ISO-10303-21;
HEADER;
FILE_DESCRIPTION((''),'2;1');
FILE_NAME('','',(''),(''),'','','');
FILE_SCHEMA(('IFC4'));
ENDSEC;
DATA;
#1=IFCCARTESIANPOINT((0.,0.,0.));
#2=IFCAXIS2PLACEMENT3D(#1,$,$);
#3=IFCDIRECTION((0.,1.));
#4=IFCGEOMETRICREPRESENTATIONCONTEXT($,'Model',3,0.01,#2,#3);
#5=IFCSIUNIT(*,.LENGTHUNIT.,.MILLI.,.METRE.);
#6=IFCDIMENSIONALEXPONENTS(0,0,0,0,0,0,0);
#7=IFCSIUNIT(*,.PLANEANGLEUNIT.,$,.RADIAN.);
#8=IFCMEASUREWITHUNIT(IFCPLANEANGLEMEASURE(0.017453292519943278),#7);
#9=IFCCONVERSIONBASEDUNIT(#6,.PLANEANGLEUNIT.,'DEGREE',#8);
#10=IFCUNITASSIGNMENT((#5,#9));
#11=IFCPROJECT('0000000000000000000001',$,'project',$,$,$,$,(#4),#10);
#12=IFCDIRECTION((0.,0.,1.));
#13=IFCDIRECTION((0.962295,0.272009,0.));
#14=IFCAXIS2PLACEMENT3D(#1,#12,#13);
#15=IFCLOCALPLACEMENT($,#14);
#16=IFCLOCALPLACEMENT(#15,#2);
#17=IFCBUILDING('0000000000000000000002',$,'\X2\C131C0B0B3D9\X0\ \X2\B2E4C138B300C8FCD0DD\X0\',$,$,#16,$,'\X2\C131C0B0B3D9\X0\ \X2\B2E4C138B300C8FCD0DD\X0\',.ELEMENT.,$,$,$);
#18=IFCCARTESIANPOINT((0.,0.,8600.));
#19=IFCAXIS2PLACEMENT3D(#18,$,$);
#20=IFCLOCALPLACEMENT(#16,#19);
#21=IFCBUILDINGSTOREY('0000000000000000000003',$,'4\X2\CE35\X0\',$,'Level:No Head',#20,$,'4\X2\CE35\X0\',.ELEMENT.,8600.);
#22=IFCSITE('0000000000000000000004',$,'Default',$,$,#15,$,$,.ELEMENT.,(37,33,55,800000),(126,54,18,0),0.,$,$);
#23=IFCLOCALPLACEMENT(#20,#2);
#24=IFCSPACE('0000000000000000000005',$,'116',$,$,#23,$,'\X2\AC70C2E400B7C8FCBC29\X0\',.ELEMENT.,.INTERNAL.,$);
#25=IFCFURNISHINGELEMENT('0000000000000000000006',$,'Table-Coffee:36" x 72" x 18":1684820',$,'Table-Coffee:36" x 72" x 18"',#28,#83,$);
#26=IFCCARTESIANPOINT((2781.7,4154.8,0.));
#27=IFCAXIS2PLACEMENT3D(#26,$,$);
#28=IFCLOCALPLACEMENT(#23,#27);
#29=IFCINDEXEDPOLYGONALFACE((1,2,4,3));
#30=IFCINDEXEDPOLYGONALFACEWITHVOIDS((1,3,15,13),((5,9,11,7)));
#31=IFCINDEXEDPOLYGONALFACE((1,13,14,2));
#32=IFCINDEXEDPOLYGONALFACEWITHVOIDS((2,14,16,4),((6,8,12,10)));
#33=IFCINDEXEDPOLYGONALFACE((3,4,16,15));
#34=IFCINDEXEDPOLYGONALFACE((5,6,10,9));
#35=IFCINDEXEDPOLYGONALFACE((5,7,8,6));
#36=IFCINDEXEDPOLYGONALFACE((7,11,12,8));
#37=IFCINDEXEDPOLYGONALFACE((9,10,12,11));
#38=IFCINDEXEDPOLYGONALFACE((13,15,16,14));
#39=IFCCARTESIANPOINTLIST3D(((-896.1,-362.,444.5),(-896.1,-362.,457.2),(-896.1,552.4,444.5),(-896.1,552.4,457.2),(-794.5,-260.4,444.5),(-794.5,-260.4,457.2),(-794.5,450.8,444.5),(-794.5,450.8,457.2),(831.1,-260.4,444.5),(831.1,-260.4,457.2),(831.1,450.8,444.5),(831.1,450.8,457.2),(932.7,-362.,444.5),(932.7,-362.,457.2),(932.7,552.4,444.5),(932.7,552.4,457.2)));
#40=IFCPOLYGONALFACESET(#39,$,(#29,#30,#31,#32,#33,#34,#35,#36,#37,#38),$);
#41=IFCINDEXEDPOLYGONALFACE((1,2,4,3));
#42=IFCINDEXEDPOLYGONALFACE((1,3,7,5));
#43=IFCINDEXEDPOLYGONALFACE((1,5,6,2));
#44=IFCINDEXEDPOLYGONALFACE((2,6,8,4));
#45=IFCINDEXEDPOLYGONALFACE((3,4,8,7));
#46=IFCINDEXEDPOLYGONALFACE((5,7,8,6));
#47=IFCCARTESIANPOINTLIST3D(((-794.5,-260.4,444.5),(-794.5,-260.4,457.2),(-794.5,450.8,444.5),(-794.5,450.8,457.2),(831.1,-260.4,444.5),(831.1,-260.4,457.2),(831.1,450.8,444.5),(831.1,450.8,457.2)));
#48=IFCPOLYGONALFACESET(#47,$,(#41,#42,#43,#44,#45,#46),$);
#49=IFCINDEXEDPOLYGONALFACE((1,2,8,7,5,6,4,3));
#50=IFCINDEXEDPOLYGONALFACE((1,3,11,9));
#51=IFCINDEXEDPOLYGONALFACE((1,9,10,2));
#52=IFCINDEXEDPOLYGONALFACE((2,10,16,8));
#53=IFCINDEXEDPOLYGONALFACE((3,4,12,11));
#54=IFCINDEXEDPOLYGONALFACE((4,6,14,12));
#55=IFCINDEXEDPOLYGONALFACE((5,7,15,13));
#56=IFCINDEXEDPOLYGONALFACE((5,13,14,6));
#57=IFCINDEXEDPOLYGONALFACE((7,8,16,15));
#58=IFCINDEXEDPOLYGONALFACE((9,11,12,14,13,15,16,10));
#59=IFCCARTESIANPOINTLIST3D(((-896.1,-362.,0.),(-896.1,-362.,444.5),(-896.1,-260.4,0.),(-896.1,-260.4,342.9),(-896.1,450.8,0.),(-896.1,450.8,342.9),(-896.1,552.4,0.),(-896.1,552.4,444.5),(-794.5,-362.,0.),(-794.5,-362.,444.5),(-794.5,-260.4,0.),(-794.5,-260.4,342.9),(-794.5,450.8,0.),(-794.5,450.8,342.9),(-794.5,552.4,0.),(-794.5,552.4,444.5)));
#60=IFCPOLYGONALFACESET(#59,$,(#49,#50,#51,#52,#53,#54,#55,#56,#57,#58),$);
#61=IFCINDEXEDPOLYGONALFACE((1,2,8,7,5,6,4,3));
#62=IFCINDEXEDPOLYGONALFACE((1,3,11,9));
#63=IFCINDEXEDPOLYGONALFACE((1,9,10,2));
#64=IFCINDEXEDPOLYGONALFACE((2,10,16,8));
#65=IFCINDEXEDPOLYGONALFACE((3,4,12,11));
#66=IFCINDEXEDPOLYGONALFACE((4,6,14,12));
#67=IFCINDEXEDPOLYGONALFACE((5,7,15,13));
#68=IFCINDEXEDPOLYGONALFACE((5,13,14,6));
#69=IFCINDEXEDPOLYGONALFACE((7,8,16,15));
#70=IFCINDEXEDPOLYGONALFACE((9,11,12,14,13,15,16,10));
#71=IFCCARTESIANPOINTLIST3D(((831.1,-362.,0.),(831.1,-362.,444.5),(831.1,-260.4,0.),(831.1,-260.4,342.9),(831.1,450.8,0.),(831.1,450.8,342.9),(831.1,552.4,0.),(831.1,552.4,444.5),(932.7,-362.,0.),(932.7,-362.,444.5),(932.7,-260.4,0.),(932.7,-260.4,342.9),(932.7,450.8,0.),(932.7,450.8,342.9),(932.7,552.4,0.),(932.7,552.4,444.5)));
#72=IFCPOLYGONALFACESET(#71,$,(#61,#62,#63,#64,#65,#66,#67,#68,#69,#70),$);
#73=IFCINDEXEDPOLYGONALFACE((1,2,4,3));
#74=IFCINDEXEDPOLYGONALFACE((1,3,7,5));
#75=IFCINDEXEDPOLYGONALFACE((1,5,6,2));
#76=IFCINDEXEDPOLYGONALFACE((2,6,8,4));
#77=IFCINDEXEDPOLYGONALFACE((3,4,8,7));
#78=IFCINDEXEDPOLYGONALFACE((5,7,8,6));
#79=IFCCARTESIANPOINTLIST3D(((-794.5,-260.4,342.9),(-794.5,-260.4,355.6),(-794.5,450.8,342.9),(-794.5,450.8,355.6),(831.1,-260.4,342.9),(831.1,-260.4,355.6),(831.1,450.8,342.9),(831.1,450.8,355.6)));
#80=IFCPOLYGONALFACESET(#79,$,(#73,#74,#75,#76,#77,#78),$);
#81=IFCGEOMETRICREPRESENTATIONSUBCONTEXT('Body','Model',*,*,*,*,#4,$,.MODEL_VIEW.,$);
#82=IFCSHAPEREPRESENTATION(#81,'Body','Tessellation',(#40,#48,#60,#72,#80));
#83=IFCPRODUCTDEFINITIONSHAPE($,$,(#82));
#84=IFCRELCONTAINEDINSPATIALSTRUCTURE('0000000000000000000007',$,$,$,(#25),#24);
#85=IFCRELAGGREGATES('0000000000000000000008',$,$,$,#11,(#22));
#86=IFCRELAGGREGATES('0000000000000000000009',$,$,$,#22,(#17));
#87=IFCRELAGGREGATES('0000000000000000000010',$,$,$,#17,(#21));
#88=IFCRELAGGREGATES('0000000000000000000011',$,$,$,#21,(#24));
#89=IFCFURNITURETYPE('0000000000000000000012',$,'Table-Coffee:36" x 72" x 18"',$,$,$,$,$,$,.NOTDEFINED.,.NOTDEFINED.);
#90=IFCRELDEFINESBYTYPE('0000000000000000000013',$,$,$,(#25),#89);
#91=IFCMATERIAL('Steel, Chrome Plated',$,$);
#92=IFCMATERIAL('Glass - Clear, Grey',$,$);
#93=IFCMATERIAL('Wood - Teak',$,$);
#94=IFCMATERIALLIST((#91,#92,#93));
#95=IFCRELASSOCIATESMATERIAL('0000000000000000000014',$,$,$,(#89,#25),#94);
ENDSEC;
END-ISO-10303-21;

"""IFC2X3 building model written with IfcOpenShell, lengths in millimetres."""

from ifc_helpers import new_model, entity, si_unit, converted_unit, direction, frame, origin, origin_2d_with_axis, place, context, subcontext, project, spatial, polyline, rectangle, outline, extrude, source, transform, mapped, material, material_list, type_object, type_shapes, element, save


model = new_model("IFC2X3")

# Units and contexts
model_context = context("Model", 3, precision=0.01, world=origin(), true_north=direction((0.0, 1.0)))
body_context = subcontext(model_context, "Body", "Model", "MODEL_VIEW")
ifc_project = project(units=[si_unit("LENGTHUNIT", "METRE", prefix="MILLI"), converted_unit("PLANEANGLEUNIT", "DEGREE", entity("IfcPlaneAngleMeasure", 0.017453292519943278), si_unit("PLANEANGLEUNIT", "RADIAN"), dimensions=[0, 0, 0, 0, 0, 0, 0])], contexts=[model_context])

# Site, building, storey
site_placement = place(None, frame((0.0, 0.0, 0.0), z_axis=(0.0, 0.0, 1.0), x_axis=(0.962295, 0.272009, 0.0)))
site = spatial("IfcSite", under=ifc_project, at=site_placement, Name="Default", CompositionType="ELEMENT", RefLatitude=(37, 33, 55, 800000), RefLongitude=(126, 54, 18, 0), RefElevation=0.0)
building_placement = place(site_placement, origin())
building = spatial("IfcBuilding", under=site, at=building_placement, Name="성산동 다세대주택", LongName="성산동 다세대주택", CompositionType="ELEMENT")
storey_placement = place(building_placement, frame((0.0, 0.0, 8600.0)))
storey = spatial("IfcBuildingStorey", under=building, at=storey_placement, Name="4층", ObjectType="Level:No Head", LongName="4층", CompositionType="ELEMENT", Elevation=8600.0)

# Shared definitions
space_1_placement = place(storey_placement, origin())
space_1 = spatial("IfcSpace", under=storey, at=space_1_placement, Name="116", LongName="거실·주방", CompositionType="ELEMENT", InteriorOrExteriorSpace="INTERNAL")

# Furnishing element
ifc_material_1 = material(Name="Steel, Chrome Plated")
ifc_material_2 = material(Name="Glass - Clear, Grey")
ifc_material_3 = material(Name="Wood - Teak")
ifc_material_list_1 = material_list([ifc_material_1, ifc_material_2, ifc_material_3])
furniture_type_1 = type_object("IfcFurnitureType", Name="Table-Coffee:36\" x 72\" x 18\"", AssemblyPlace="NOTDEFINED", material=ifc_material_list_1)
shared_shape_1 = source(origin(), body_context, "Body", "SweptSolid", [
    extrude(outline(polyline([(-914.4, -457.2), (914.4, -457.2), (914.4, 457.2), (-914.4, 457.2), (-914.4, -457.2)]), holes=[polyline([(-812.8, -355.6), (-812.8, 355.6), (812.8, 355.6), (812.8, -355.6), (-812.8, -355.6)])]), frame((18.3, 95.2, 444.5), z_axis=(0.0, 0.0, 1.0), x_axis=(-1.0, 0.0, 0.0)), (0.0, 0.0, 1.0), 12.7),
    extrude(rectangle(XDim=1625.6, YDim=711.2, at=origin_2d_with_axis()), frame((18.3, 95.2, 444.5), z_axis=(0.0, 0.0, 1.0), x_axis=(-1.0, 0.0, 0.0)), (0.0, 0.0, 1.0), 12.7),
    extrude(outline(polyline([(-457.2, -247.7), (457.2, -247.7), (457.2, 196.9), (355.6, 196.9), (355.6, -146.0), (-355.6, -146.0), (-355.6, 196.9), (-457.2, 196.9), (-457.2, -247.7)])), frame((-896.1, 95.2, 196.9), z_axis=(1.0, 0.0, 0.0), x_axis=(0.0, -1.0, 0.0)), (0.0, 0.0, 1.0), 101.6),
    extrude(outline(polyline([(-196.8, -457.2), (247.6, -457.2), (247.6, 457.2), (-196.8, 457.2), (-196.8, 355.6), (146.1, 355.6), (146.1, -355.6), (-196.8, -355.6), (-196.8, -457.2)])), frame((831.1, 95.2, 196.8), z_axis=(1.0, 0.0, 0.0), x_axis=(0.0, 0.0, 1.0)), (0.0, 0.0, 1.0), 101.6),
    extrude(rectangle(XDim=1625.6, YDim=711.2, at=origin_2d_with_axis()), frame((18.3, 95.2, 342.9), z_axis=(0.0, 0.0, 1.0), x_axis=(-1.0, 0.0, 0.0)), (0.0, 0.0, 1.0), 12.7),
])
type_shapes(furniture_type_1, [shared_shape_1])
furnishing_1_placement = place(space_1_placement, frame((2781.7, 4154.8, 0.0)))
element("IfcFurnishingElement", 1, at=furnishing_1_placement, inside=space_1, type_object=furniture_type_1, material=ifc_material_list_1, Name="Table-Coffee:36\" x 72\" x 18\":1684820", ObjectType="Table-Coffee:36\" x 72\" x 18\"", context=body_context, shape_type="MappedRepresentation", body=[
    mapped(shared_shape_1, transform((0.0, 0.0, 0.0), scale=1.0)),
])

save(model, "model.ifc")
